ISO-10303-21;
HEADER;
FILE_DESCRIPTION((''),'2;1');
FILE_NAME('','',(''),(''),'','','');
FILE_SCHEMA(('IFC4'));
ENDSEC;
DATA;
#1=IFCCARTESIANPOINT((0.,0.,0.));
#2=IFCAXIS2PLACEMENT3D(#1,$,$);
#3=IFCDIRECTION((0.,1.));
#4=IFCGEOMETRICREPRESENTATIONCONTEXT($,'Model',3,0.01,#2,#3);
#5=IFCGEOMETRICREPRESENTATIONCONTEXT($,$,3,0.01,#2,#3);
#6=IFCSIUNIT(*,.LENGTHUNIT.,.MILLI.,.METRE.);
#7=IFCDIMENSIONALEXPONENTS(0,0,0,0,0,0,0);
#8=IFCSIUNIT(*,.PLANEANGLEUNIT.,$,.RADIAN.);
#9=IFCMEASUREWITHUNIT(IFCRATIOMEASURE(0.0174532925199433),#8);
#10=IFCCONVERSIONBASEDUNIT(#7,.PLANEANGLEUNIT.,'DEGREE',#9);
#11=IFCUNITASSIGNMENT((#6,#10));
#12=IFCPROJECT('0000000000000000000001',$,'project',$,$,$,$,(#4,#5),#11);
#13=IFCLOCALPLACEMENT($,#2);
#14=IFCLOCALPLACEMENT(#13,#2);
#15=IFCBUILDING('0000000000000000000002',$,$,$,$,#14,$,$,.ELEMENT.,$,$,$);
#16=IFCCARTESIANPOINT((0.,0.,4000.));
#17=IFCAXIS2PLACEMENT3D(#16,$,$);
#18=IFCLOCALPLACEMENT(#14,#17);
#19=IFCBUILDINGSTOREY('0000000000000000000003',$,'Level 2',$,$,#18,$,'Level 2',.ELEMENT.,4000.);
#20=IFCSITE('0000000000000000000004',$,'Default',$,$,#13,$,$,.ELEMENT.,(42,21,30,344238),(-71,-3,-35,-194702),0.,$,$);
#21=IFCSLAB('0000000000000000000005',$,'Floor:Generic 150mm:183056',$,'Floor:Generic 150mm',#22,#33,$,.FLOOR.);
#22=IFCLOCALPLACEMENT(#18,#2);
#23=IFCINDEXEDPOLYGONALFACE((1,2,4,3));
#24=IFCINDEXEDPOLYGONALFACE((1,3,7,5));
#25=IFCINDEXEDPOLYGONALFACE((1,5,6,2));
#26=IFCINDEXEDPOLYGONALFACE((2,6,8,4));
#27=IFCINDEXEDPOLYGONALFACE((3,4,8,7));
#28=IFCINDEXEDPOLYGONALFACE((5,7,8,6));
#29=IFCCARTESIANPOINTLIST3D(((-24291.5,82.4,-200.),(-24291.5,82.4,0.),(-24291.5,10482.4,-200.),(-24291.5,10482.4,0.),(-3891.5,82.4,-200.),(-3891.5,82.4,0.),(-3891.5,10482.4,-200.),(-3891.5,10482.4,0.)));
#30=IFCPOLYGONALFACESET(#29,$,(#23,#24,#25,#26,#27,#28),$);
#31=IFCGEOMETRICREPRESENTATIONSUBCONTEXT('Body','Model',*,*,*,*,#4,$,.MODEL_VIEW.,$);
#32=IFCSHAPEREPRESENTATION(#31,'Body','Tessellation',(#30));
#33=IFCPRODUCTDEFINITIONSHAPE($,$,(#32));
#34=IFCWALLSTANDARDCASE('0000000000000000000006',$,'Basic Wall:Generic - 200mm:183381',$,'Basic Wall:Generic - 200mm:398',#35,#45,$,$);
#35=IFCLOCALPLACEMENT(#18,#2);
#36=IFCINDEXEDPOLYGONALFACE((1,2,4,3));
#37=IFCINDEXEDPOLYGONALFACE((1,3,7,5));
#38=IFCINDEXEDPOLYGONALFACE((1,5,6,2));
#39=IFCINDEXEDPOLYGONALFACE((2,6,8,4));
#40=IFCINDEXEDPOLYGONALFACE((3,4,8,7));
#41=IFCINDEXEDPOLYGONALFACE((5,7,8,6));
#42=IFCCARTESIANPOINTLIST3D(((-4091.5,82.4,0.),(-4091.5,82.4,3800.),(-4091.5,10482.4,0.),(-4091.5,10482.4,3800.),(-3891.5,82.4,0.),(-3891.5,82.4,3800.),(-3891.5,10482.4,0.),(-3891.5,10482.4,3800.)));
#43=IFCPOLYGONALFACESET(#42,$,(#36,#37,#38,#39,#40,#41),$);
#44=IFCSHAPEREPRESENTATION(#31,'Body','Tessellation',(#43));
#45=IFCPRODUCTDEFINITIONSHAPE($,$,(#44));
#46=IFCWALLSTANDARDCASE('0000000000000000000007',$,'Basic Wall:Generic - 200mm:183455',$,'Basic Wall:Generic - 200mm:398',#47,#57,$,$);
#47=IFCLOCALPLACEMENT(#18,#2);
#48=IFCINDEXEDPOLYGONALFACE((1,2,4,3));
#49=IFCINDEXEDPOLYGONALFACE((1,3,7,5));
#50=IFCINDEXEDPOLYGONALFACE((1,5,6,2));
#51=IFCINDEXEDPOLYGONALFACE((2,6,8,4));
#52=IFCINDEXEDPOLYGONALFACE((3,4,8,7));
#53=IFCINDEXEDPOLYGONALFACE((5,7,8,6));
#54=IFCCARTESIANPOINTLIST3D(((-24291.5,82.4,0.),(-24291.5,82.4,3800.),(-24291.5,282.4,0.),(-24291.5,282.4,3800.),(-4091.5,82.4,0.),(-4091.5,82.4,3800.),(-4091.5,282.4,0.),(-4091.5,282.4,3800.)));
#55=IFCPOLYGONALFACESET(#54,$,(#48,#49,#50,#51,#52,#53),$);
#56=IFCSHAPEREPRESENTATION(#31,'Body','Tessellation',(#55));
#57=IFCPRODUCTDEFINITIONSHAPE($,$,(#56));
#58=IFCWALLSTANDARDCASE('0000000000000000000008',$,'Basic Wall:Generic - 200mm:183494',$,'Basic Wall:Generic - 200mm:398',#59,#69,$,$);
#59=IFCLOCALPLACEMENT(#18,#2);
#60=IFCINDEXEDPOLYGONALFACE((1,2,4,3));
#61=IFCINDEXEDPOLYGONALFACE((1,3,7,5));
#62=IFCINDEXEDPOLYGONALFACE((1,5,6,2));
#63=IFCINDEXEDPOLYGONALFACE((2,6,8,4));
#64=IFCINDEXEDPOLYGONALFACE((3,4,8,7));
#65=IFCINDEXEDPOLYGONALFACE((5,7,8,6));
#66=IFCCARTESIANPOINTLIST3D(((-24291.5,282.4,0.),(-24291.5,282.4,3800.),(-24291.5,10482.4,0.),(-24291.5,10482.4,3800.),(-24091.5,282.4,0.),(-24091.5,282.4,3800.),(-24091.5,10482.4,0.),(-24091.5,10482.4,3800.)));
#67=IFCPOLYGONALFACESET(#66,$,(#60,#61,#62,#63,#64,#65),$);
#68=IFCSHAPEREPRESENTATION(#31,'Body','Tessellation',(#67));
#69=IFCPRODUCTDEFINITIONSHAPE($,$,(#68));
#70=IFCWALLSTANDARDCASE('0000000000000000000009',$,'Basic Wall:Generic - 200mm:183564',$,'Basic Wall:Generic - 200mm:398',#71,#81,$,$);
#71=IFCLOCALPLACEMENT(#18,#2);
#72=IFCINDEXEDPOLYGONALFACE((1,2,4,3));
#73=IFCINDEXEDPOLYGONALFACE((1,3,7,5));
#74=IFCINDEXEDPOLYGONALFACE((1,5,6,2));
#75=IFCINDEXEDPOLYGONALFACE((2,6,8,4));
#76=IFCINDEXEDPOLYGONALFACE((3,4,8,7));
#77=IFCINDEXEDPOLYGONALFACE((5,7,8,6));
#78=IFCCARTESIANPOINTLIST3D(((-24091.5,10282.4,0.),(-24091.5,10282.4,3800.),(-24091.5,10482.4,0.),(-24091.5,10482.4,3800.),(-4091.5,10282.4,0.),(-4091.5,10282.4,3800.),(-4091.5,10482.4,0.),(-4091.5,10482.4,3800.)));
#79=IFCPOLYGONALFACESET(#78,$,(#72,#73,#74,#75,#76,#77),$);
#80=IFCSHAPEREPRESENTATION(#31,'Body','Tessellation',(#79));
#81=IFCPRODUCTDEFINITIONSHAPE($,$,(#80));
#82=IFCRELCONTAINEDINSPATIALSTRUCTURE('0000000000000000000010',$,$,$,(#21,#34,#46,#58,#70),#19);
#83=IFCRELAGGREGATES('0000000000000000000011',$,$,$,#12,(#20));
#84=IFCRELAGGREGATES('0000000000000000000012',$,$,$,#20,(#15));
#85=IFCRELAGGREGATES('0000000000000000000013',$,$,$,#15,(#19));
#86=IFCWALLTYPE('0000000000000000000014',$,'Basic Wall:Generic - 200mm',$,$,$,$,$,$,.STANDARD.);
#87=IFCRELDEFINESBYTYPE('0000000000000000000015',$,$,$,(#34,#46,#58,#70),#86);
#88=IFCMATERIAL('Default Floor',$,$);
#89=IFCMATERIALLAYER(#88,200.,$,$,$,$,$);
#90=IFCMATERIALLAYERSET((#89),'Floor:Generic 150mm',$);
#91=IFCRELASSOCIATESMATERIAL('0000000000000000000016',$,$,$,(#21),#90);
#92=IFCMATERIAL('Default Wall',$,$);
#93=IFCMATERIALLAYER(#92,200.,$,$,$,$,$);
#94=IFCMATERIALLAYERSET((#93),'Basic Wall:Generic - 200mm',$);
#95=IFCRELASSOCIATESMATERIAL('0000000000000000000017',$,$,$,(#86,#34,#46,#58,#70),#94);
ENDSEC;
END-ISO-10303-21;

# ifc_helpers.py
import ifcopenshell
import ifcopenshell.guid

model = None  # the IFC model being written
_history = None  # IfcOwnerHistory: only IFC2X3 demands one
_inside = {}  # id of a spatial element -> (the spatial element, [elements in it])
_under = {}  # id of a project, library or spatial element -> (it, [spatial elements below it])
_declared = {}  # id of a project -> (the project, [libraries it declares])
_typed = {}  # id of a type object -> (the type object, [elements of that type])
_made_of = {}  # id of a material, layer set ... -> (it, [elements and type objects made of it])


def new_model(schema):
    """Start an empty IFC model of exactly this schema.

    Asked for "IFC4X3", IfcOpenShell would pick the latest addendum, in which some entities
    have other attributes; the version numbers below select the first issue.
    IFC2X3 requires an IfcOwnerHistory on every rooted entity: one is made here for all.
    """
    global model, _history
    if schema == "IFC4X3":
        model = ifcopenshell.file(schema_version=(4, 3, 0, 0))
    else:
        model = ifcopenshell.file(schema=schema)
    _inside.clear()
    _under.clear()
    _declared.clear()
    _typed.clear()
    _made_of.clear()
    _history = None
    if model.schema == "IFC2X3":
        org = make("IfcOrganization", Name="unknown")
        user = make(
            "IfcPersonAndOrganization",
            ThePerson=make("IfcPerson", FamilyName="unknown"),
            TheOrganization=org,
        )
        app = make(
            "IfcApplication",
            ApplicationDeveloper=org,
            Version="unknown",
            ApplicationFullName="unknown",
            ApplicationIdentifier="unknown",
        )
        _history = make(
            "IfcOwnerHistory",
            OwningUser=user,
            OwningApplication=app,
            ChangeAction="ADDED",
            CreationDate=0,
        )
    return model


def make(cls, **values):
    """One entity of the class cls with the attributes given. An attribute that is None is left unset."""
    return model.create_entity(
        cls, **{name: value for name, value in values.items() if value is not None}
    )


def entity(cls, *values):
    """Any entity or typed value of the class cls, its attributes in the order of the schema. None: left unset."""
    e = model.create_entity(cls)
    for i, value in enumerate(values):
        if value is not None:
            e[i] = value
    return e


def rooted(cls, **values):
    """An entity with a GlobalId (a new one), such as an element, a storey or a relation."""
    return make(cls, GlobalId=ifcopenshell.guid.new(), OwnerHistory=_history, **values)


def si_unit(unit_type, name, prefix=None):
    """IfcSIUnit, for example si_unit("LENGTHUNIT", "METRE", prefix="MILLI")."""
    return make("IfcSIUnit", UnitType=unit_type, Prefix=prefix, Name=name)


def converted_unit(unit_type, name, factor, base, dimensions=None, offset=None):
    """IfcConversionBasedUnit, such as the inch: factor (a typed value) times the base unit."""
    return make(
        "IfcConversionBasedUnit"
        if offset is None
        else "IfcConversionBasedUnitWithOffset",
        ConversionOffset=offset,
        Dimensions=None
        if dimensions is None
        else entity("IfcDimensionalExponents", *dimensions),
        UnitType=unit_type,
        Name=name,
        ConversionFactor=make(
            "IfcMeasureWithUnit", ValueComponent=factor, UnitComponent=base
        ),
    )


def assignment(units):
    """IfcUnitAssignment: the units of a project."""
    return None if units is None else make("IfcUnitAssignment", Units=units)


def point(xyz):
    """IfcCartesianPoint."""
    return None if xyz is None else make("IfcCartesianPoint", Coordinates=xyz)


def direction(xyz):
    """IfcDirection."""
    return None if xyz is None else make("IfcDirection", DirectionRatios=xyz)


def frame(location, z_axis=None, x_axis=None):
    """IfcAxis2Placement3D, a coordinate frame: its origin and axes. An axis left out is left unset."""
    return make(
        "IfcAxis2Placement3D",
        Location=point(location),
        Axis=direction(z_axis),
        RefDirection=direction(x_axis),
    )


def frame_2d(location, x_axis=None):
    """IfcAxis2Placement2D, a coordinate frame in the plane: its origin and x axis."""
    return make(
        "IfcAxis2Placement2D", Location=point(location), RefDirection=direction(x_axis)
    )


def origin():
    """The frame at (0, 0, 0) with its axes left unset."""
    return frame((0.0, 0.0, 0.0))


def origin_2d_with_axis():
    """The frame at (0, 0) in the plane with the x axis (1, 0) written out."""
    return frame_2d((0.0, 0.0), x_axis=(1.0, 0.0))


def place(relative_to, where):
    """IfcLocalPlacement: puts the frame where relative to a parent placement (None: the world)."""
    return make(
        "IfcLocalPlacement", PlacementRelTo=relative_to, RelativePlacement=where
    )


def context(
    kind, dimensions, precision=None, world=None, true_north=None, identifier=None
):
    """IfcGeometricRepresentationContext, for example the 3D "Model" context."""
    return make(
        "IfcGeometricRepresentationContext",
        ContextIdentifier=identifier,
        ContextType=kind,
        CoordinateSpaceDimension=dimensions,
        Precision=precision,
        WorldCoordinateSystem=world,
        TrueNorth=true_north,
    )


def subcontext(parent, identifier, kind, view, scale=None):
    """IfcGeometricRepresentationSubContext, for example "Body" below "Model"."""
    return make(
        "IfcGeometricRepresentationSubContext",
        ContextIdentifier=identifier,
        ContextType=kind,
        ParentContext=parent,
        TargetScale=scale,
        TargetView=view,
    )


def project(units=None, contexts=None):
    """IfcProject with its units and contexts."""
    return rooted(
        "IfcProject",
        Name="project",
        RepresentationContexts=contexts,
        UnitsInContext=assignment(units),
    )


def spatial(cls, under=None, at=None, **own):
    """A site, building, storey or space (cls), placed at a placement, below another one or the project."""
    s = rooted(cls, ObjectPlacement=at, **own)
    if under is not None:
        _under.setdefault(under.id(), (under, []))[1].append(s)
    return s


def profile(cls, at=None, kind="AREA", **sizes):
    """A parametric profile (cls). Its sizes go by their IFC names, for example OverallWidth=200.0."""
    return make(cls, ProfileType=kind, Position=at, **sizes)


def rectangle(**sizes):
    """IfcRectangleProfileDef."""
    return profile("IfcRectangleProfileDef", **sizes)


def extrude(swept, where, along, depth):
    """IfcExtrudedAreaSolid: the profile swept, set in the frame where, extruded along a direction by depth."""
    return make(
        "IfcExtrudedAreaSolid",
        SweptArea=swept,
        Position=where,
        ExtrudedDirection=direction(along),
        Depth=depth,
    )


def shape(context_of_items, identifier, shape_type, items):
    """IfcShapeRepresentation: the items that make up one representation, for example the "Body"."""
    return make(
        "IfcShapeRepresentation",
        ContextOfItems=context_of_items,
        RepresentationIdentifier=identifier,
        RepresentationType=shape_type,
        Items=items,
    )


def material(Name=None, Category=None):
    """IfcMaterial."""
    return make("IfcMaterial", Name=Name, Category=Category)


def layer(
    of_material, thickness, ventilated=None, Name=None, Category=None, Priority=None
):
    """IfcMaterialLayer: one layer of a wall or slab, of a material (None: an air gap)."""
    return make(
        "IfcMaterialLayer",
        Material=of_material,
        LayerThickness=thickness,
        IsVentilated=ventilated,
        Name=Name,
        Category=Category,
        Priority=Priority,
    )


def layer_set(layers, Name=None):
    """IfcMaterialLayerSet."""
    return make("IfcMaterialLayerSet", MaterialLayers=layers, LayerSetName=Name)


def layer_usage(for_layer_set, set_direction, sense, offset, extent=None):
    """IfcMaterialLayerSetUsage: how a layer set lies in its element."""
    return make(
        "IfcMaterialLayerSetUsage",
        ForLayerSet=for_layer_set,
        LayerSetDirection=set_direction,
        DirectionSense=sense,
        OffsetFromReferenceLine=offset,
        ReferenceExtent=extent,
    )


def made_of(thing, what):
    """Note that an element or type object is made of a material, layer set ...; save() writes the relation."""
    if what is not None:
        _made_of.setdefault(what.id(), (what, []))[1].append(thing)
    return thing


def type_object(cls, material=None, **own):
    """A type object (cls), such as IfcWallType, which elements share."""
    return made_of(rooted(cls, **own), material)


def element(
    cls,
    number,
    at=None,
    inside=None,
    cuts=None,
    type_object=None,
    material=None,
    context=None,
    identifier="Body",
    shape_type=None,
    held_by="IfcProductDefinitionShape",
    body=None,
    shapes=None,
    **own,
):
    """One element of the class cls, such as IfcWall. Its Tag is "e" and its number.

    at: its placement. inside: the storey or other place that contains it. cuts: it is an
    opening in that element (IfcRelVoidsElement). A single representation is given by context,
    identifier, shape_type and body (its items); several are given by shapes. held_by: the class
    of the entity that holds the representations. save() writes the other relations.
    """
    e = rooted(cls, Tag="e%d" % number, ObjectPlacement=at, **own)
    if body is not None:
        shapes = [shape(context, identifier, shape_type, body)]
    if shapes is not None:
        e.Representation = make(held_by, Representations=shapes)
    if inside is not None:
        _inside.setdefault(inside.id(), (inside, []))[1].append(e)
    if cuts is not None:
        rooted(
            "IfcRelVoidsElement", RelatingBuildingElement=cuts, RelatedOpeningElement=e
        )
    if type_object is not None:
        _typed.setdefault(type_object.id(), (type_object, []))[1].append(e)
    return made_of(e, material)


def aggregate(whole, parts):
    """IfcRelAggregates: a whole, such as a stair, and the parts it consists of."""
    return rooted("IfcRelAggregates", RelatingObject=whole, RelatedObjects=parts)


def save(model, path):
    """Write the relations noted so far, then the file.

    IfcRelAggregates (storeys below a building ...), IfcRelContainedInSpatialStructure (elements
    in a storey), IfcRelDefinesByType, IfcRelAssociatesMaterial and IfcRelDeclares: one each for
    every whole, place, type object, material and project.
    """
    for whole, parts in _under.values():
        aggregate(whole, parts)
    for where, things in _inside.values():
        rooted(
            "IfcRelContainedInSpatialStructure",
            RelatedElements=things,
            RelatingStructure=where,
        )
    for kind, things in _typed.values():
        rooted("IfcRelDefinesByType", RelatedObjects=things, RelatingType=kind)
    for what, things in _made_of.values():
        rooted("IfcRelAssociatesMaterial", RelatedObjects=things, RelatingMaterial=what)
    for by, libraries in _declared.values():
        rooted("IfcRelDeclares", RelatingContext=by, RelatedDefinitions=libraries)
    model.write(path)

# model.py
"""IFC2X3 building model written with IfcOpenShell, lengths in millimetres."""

from ifc_helpers import new_model, entity, si_unit, converted_unit, direction, frame, frame_2d, origin, origin_2d_with_axis, place, context, subcontext, project, spatial, rectangle, extrude, material, layer, layer_set, layer_usage, type_object, element, save


model = new_model("IFC2X3")

# Units and contexts
model_context = context("Model", 3, precision=0.01, world=origin(), true_north=direction((0.0, 1.0)))
context_of_model = context(None, 3, precision=0.01, world=origin(), true_north=direction((0.0, 1.0)))
body_context = subcontext(model_context, "Body", "Model", "MODEL_VIEW")
ifc_project = project(units=[si_unit("LENGTHUNIT", "METRE", prefix="MILLI"), converted_unit("PLANEANGLEUNIT", "DEGREE", entity("IfcRatioMeasure", 0.0174532925199433), si_unit("PLANEANGLEUNIT", "RADIAN"), dimensions=[0, 0, 0, 0, 0, 0, 0])], contexts=[model_context, context_of_model])

# Site, building, storey
site_placement = place(None, origin())
site = spatial("IfcSite", under=ifc_project, at=site_placement, Name="Default", CompositionType="ELEMENT", RefLatitude=(42, 21, 30, 344238), RefLongitude=(-71, -3, -35, -194702), RefElevation=0.0)
building_placement = place(site_placement, origin())
building = spatial("IfcBuilding", under=site, at=building_placement, CompositionType="ELEMENT")
storey_placement = place(building_placement, frame((0.0, 0.0, 4000.0)))
storey = spatial("IfcBuildingStorey", under=building, at=storey_placement, Name="Level 2", LongName="Level 2", CompositionType="ELEMENT", Elevation=4000.0)

# Slab
ifc_material_1 = material(Name="Default Floor")
ifc_layer_1 = layer(ifc_material_1, 200.0)
ifc_layer_set_1 = layer_set([ifc_layer_1], Name="Floor:Generic 150mm")
ifc_layer_usage_1 = layer_usage(ifc_layer_set_1, "AXIS3", "POSITIVE", 0.0)
slab_placement = place(storey_placement, origin())
element("IfcSlab", 1, at=slab_placement, inside=storey, material=ifc_layer_usage_1, Name="Floor:Generic 150mm:183056", ObjectType="Floor:Generic 150mm", PredefinedType="FLOOR", context=body_context, shape_type="SweptSolid", body=[
    extrude(rectangle(XDim=10400.0, YDim=20400.0, at=origin_2d_with_axis()), frame((-14091.5, 5282.4, 0.0), z_axis=(0.0, 0.0, -1.0), x_axis=(0.0, 1.0, 0.0)), (0.0, 0.0, 1.0), 200.0),
])

# Walls
ifc_material_2 = material(Name="Default Wall")
ifc_layer_2 = layer(ifc_material_2, 200.0)
ifc_layer_set_2 = layer_set([ifc_layer_2], Name="Basic Wall:Generic - 200mm")
ifc_layer_usage_2 = layer_usage(ifc_layer_set_2, "AXIS2", "NEGATIVE", 100.0)
wall_type = type_object("IfcWallType", Name="Basic Wall:Generic - 200mm", PredefinedType="STANDARD", material=ifc_layer_set_2)
wall_1_placement = place(storey_placement, frame((-3991.5, 10482.4, 0.0), z_axis=(0.0, 0.0, 1.0), x_axis=(0.0, -1.0, 0.0)))
element("IfcWallStandardCase", 2, at=wall_1_placement, inside=storey, type_object=wall_type, material=ifc_layer_usage_2, Name="Basic Wall:Generic - 200mm:183381", ObjectType="Basic Wall:Generic - 200mm:398", context=body_context, shape_type="SweptSolid", body=[
    extrude(rectangle(XDim=10400.0, YDim=200.0, at=frame_2d((5200.0, 0.0), x_axis=(-1.0, 0.0))), origin(), (0.0, 0.0, 1.0), 3800.0),
])
ifc_layer_usage_3 = layer_usage(ifc_layer_set_2, "AXIS2", "NEGATIVE", 100.0)
wall_2_placement = place(storey_placement, frame((-4091.5, 182.4, 0.0), z_axis=(0.0, 0.0, 1.0), x_axis=(-1.0, 0.0, 0.0)))
element("IfcWallStandardCase", 3, at=wall_2_placement, inside=storey, type_object=wall_type, material=ifc_layer_usage_3, Name="Basic Wall:Generic - 200mm:183455", ObjectType="Basic Wall:Generic - 200mm:398", context=body_context, shape_type="SweptSolid", body=[
    extrude(rectangle(XDim=20200.0, YDim=200.0, at=frame_2d((10100.0, 0.0), x_axis=(-1.0, 0.0))), origin(), (0.0, 0.0, 1.0), 3800.0),
])
ifc_layer_usage_4 = layer_usage(ifc_layer_set_2, "AXIS2", "NEGATIVE", 100.0)
wall_3_placement = place(storey_placement, frame((-24191.5, 282.4, 0.0), z_axis=(0.0, 0.0, 1.0), x_axis=(0.0, 1.0, 0.0)))
element("IfcWallStandardCase", 4, at=wall_3_placement, inside=storey, type_object=wall_type, material=ifc_layer_usage_4, Name="Basic Wall:Generic - 200mm:183494", ObjectType="Basic Wall:Generic - 200mm:398", context=body_context, shape_type="SweptSolid", body=[
    extrude(rectangle(XDim=10200.0, YDim=200.0, at=frame_2d((5100.0, 0.0), x_axis=(-1.0, 0.0))), origin(), (0.0, 0.0, 1.0), 3800.0),
])
ifc_layer_usage_5 = layer_usage(ifc_layer_set_2, "AXIS2", "NEGATIVE", 100.0)
wall_4_placement = place(storey_placement, frame((-24091.5, 10382.4, 0.0)))
element("IfcWallStandardCase", 5, at=wall_4_placement, inside=storey, type_object=wall_type, material=ifc_layer_usage_5, Name="Basic Wall:Generic - 200mm:183564", ObjectType="Basic Wall:Generic - 200mm:398", context=body_context, shape_type="SweptSolid", body=[
    extrude(rectangle(XDim=20000.0, YDim=200.0, at=frame_2d((10000.0, 0.0), x_axis=(-1.0, 0.0))), origin(), (0.0, 0.0, 1.0), 3800.0),
])

save(model, "model.ifc")
